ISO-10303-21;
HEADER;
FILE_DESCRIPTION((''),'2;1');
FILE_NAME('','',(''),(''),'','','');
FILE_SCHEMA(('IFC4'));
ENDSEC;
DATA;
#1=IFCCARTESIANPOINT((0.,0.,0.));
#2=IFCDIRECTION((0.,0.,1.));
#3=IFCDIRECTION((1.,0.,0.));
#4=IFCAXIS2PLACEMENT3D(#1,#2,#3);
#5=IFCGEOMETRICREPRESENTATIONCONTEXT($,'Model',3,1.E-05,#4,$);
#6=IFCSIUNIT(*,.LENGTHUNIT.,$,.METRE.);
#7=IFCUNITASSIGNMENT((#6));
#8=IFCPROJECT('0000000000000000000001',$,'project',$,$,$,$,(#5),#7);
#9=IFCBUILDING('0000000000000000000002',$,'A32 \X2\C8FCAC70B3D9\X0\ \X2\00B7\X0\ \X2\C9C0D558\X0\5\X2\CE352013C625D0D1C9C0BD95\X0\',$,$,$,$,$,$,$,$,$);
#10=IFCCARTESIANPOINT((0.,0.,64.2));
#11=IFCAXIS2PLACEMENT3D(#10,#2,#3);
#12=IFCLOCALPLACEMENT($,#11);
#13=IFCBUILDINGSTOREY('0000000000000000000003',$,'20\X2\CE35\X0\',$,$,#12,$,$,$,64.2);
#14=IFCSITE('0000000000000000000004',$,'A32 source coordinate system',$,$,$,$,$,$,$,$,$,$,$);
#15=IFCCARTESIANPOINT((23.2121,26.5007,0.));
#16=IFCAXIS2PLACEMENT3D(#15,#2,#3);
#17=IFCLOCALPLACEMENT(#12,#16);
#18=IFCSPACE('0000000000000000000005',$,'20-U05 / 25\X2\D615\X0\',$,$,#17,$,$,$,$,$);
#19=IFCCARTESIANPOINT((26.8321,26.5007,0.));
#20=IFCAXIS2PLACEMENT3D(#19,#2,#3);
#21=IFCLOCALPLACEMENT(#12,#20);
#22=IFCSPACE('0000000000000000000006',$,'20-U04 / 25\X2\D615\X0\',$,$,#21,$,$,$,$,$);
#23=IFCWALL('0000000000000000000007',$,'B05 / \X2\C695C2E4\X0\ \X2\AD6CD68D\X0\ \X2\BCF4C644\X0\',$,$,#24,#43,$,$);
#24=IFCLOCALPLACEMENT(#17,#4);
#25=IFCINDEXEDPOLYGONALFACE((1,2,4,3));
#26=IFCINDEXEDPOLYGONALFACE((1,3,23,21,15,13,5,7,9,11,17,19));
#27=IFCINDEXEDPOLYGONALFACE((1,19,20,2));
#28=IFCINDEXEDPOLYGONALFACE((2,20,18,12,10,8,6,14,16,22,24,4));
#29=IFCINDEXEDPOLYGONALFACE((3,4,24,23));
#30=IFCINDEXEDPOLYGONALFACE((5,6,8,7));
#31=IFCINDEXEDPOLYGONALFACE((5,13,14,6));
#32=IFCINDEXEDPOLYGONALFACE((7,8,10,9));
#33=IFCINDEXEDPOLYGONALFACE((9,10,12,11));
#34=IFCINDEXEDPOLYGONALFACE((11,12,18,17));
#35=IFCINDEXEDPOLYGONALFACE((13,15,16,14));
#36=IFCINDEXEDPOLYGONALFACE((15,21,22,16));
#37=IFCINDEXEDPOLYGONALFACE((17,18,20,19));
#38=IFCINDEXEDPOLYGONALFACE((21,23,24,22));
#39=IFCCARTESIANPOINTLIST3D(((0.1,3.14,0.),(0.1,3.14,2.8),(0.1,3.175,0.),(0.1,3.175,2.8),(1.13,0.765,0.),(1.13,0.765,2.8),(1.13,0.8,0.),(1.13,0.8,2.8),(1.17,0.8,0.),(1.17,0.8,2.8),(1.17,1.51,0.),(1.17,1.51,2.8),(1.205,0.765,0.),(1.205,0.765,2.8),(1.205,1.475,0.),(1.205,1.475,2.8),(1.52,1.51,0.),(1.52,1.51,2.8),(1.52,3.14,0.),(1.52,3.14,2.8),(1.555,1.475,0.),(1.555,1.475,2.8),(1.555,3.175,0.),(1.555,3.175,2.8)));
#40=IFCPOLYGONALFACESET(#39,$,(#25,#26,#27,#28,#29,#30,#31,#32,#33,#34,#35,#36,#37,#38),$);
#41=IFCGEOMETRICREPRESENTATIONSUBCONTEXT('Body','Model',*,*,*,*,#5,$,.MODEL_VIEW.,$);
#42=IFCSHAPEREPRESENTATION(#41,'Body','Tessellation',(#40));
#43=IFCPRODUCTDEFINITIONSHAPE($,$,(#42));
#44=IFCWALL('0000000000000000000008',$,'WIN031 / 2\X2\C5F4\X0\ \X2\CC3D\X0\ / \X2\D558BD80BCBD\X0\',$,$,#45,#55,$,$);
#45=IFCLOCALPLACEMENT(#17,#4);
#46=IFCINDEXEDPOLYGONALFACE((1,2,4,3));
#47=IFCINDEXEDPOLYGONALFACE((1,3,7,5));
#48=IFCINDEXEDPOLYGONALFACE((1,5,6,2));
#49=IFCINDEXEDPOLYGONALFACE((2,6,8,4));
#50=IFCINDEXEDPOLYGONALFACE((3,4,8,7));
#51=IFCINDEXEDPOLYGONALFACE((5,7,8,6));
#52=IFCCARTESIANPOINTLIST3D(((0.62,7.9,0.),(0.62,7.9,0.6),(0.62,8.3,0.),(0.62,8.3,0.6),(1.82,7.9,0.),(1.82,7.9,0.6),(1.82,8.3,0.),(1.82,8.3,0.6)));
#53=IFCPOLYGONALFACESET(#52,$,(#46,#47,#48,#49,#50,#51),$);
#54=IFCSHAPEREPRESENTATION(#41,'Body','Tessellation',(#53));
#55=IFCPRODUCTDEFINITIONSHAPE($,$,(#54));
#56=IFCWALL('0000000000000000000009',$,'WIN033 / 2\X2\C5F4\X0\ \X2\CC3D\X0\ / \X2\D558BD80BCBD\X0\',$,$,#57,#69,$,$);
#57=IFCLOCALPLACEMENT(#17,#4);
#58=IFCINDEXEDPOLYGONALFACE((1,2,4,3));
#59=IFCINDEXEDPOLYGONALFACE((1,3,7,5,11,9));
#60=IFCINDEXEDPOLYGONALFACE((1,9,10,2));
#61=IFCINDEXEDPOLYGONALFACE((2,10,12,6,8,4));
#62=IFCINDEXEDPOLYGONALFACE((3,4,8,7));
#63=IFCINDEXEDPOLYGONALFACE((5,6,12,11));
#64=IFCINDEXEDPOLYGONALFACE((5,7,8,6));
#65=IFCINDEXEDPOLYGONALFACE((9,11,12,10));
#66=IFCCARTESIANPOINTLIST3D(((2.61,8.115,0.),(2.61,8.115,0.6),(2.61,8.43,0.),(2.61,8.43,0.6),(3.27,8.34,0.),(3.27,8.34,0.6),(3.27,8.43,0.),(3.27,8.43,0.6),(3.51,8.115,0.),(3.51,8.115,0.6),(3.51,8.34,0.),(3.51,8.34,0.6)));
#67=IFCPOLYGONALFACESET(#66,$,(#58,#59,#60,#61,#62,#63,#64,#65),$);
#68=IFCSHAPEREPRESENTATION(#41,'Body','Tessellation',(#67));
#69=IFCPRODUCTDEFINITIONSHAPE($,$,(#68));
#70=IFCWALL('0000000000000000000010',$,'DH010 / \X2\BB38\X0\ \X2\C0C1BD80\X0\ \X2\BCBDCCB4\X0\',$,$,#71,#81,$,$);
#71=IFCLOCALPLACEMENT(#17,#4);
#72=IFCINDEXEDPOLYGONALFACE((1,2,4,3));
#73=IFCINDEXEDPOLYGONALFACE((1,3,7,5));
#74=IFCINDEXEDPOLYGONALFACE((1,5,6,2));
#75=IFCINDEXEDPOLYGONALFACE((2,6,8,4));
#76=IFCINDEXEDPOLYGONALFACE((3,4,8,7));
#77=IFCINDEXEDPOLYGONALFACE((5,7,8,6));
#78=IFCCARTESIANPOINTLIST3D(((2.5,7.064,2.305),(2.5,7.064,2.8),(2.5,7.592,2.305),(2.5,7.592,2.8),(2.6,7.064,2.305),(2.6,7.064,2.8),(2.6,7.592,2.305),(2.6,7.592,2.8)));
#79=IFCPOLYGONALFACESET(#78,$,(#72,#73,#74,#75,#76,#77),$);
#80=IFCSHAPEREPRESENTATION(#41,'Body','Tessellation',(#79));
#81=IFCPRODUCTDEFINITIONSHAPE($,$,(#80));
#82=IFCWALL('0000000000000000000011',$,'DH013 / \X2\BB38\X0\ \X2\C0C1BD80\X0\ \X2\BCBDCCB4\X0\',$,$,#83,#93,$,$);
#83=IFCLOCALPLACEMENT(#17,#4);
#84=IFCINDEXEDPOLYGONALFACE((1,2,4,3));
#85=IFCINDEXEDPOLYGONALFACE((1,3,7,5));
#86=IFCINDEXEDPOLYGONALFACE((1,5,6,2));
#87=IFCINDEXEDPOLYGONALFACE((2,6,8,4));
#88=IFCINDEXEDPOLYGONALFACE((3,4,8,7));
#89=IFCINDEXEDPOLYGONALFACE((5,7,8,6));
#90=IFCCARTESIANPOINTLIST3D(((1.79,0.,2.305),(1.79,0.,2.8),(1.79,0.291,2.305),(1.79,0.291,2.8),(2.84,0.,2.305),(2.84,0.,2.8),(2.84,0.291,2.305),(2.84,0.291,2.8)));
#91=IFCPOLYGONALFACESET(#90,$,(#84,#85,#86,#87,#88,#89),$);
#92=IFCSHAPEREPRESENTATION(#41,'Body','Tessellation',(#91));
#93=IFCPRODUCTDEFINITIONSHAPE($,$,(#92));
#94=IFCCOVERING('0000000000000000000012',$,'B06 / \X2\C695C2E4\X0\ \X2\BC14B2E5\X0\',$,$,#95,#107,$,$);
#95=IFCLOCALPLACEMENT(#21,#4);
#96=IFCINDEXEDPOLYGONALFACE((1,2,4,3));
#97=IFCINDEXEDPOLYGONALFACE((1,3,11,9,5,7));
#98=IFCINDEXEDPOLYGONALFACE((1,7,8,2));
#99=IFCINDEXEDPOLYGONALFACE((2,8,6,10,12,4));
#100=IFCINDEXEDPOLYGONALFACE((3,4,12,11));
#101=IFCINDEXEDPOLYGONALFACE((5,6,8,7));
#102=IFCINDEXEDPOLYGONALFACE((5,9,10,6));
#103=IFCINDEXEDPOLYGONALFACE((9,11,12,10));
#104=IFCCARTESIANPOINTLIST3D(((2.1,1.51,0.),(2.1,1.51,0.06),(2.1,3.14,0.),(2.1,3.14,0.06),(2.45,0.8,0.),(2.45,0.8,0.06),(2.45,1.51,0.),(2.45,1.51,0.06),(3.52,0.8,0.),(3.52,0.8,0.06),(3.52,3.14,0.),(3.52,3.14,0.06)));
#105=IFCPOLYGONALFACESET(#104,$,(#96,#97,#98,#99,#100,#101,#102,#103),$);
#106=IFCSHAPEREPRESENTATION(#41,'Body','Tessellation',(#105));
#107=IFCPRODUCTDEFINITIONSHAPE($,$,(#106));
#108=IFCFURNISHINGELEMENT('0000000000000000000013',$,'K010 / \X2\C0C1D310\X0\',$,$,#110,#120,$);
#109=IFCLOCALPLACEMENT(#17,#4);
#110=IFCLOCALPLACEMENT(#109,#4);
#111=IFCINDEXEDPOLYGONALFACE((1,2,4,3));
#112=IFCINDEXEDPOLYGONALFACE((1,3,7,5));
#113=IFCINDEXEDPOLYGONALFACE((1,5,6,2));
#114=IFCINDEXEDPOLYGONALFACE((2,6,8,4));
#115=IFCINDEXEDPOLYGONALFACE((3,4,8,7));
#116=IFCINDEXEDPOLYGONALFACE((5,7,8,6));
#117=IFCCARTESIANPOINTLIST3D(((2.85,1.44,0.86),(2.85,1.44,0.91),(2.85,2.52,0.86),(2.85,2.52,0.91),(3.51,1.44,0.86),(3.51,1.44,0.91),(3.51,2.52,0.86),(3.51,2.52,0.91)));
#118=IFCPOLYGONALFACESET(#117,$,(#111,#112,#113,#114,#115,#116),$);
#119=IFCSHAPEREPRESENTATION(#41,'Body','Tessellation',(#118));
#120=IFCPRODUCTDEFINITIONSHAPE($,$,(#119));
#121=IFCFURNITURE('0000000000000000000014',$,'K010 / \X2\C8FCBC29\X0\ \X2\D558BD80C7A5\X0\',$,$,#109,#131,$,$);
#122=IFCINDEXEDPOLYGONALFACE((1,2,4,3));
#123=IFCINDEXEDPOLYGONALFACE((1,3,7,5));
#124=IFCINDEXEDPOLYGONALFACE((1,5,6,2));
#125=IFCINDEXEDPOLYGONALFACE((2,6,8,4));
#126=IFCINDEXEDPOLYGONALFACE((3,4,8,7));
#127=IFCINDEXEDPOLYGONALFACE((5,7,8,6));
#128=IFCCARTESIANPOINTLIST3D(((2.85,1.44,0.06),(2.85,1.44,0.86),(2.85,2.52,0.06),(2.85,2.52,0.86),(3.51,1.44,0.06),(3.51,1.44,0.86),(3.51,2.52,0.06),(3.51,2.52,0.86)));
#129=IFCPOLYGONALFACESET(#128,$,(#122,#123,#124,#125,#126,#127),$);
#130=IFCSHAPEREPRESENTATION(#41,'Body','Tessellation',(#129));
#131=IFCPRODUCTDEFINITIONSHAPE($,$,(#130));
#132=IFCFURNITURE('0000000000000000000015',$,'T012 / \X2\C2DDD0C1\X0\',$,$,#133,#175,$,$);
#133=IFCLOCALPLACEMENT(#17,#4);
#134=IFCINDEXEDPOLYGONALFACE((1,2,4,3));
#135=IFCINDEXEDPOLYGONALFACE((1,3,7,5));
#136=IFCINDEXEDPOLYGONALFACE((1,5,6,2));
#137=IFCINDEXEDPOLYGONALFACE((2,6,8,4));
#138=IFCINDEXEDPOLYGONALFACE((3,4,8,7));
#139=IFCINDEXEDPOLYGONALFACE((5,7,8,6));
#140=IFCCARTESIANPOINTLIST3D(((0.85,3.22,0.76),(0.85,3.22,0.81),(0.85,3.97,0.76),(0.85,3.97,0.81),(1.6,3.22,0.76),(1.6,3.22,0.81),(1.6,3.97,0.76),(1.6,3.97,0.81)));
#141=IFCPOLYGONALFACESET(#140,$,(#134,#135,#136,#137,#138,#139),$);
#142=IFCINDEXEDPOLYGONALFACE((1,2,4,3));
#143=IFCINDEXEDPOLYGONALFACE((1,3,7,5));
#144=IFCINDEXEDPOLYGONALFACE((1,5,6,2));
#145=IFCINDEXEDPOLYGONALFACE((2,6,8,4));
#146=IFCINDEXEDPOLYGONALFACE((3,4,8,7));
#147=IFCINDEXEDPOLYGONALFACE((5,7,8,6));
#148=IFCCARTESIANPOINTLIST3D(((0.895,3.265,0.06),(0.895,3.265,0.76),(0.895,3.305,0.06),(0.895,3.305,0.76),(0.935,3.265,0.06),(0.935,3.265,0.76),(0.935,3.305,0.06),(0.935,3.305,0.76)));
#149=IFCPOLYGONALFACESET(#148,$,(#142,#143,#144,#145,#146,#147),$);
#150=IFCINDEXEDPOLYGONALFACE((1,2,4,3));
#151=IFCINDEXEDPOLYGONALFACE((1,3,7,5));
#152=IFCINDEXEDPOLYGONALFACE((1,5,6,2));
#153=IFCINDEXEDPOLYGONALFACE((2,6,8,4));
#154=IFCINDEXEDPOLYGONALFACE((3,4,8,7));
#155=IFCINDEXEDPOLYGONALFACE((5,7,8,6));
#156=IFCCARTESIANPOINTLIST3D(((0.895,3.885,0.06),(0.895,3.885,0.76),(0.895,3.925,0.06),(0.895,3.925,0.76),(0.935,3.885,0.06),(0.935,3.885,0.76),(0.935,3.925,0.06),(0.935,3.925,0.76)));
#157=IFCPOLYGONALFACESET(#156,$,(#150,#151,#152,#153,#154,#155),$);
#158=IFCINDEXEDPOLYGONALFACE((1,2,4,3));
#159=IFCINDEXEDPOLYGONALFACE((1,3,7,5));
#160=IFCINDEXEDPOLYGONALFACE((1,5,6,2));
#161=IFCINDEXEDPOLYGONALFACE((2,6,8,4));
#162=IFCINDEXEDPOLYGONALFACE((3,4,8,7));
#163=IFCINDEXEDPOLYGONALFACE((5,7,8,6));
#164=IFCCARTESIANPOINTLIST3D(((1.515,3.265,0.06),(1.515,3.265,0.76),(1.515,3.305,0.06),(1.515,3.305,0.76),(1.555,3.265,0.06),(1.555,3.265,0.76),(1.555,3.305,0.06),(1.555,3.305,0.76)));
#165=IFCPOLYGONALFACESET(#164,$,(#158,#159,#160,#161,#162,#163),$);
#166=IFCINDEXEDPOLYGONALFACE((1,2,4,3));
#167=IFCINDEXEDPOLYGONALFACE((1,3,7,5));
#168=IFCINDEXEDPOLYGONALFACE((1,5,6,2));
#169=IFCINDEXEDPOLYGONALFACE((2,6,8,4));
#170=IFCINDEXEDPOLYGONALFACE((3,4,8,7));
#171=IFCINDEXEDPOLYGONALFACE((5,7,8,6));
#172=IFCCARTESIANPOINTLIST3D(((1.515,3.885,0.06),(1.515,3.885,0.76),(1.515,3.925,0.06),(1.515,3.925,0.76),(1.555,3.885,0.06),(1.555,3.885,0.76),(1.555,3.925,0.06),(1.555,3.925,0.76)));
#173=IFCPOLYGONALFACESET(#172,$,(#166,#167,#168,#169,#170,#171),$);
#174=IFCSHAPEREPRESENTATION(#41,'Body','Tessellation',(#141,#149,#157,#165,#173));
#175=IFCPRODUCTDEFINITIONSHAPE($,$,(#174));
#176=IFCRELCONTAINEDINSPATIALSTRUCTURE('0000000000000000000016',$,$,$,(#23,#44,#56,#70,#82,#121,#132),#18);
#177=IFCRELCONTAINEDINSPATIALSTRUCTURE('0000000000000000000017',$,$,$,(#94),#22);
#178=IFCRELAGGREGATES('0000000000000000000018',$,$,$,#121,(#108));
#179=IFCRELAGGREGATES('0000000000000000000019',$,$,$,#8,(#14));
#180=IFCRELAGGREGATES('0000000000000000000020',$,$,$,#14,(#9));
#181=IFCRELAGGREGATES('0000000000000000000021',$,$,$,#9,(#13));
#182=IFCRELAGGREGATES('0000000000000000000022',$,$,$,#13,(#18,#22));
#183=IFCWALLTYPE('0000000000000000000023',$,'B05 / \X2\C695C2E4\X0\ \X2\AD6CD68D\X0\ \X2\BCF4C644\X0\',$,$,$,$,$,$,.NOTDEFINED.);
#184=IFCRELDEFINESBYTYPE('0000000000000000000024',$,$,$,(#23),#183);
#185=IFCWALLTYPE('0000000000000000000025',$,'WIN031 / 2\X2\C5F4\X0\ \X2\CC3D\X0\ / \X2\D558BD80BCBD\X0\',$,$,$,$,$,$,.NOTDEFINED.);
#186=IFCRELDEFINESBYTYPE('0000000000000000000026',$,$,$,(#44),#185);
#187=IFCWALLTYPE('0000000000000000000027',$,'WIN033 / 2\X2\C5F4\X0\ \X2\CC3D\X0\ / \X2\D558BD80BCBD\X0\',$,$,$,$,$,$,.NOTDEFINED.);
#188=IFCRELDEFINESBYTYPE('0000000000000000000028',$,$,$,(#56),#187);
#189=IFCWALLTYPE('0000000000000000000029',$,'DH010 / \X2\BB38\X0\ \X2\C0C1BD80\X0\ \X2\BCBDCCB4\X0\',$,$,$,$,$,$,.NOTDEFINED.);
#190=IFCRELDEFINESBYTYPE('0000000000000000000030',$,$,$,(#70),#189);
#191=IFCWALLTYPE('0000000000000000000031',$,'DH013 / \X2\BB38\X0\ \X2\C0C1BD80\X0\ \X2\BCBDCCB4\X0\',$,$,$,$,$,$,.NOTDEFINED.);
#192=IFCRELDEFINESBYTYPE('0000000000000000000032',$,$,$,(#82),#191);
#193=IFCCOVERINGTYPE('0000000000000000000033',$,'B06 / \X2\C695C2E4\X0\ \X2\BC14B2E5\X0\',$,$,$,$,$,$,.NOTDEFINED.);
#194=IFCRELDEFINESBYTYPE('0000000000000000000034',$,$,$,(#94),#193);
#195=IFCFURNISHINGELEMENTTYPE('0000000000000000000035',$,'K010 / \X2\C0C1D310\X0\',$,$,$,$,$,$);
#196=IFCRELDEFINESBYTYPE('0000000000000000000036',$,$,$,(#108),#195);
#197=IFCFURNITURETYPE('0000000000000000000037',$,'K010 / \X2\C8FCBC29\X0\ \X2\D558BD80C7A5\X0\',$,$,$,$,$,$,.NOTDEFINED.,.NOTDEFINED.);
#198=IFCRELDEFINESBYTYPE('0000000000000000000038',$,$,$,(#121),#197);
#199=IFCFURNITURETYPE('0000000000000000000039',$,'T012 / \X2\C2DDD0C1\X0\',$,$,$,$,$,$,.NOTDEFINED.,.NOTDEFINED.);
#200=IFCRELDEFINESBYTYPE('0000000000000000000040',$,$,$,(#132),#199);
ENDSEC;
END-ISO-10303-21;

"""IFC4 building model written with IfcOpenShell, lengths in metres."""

from ifc_helpers import new_model, si_unit, frame, origin, origin_with_axes, place, context, subcontext, project, spatial, polyline, outline, extrude, source, transform, mapped, type_object, type_shapes, element, aggregate, save


model = new_model("IFC4")

# Units and contexts
model_context = context("Model", 3, precision=1e-05, world=origin_with_axes())
body_context = subcontext(model_context, "Body", "Model", "MODEL_VIEW")
ifc_project = project(units=[si_unit("LENGTHUNIT", "METRE")], contexts=[model_context])

# Site, building, storey, space
site = spatial("IfcSite", under=ifc_project, Name="A32 source coordinate system")
building = spatial("IfcBuilding", under=site, Name="A32 주거동 · 지하5층–옥탑지붕")
storey_placement = place(None, frame((0.0, 0.0, 64.2), z_axis=(0.0, 0.0, 1.0), x_axis=(1.0, 0.0, 0.0)))
storey = spatial("IfcBuildingStorey", under=building, at=storey_placement, Name="20층", Elevation=64.2)
space_1_placement = place(storey_placement, frame((23.2121, 26.5007, 0.0), z_axis=(0.0, 0.0, 1.0), x_axis=(1.0, 0.0, 0.0)))
space_1 = spatial("IfcSpace", under=storey, at=space_1_placement, Name="20-U05 / 25형")

# Walls
wall_type_1 = type_object("IfcWallType", Name="B05 / 욕실 구획 보완", PredefinedType="NOTDEFINED")
shared_shape_1 = source(origin(), body_context, "Body", "SweptSolid", [
    extrude(outline(polyline([(1.17, 1.51), (1.52, 1.51), (1.52, 3.14), (0.1, 3.14), (0.1, 3.175), (1.555, 3.175), (1.555, 1.475), (1.205, 1.475), (1.205, 0.765), (1.13, 0.765), (1.13, 0.8), (1.17, 0.8), (1.17, 1.51)])), origin(), (0.0, 0.0, 1.0), 2.8),
])
type_shapes(wall_type_1, [shared_shape_1])
wall_1_placement = place(space_1_placement, origin_with_axes())
element("IfcWall", 1, at=wall_1_placement, inside=space_1, type_object=wall_type_1, Name="B05 / 욕실 구획 보완", context=body_context, shape_type="MappedRepresentation", body=[
    mapped(shared_shape_1, transform((0.0, 0.0, 0.0), scale=1.0)),
])
wall_type_2 = type_object("IfcWallType", Name="WIN031 / 2열 창 / 하부벽", PredefinedType="NOTDEFINED")
shared_shape_2 = source(origin(), body_context, "Body", "SweptSolid", [
    extrude(outline(polyline([(0.62, 8.3), (1.82, 8.3), (1.82, 7.9), (0.62, 7.9), (0.62, 8.3)])), origin(), (0.0, 0.0, 1.0), 0.6),
])
type_shapes(wall_type_2, [shared_shape_2])
wall_2_placement = place(space_1_placement, origin_with_axes())
element("IfcWall", 2, at=wall_2_placement, inside=space_1, type_object=wall_type_2, Name="WIN031 / 2열 창 / 하부벽", context=body_context, shape_type="MappedRepresentation", body=[
    mapped(shared_shape_2, transform((0.0, 0.0, 0.0), scale=1.0)),
])
wall_type_3 = type_object("IfcWallType", Name="WIN033 / 2열 창 / 하부벽", PredefinedType="NOTDEFINED")
shared_shape_3 = source(origin(), body_context, "Body", "SweptSolid", [
    extrude(outline(polyline([(2.61, 8.43), (3.27, 8.43), (3.27, 8.34), (3.51, 8.34), (3.51, 8.115), (2.61, 8.115), (2.61, 8.43)])), origin(), (0.0, 0.0, 1.0), 0.6),
])
type_shapes(wall_type_3, [shared_shape_3])
wall_3_placement = place(space_1_placement, origin_with_axes())
element("IfcWall", 3, at=wall_3_placement, inside=space_1, type_object=wall_type_3, Name="WIN033 / 2열 창 / 하부벽", context=body_context, shape_type="MappedRepresentation", body=[
    mapped(shared_shape_3, transform((0.0, 0.0, 0.0), scale=1.0)),
])
wall_type_4 = type_object("IfcWallType", Name="DH010 / 문 상부 벽체", PredefinedType="NOTDEFINED")
shared_shape_4 = source(origin(), body_context, "Body", "SweptSolid", [
    extrude(outline(polyline([(2.5, 7.592), (2.6, 7.592), (2.6, 7.064), (2.5, 7.064), (2.5, 7.592)])), frame((0.0, 0.0, 2.305)), (0.0, 0.0, 1.0), 0.495),
])
type_shapes(wall_type_4, [shared_shape_4])
wall_4_placement = place(space_1_placement, origin_with_axes())
element("IfcWall", 4, at=wall_4_placement, inside=space_1, type_object=wall_type_4, Name="DH010 / 문 상부 벽체", context=body_context, shape_type="MappedRepresentation", body=[
    mapped(shared_shape_4, transform((0.0, 0.0, 0.0), scale=1.0)),
])
wall_type_5 = type_object("IfcWallType", Name="DH013 / 문 상부 벽체", PredefinedType="NOTDEFINED")
shared_shape_5 = source(origin(), body_context, "Body", "SweptSolid", [
    extrude(outline(polyline([(2.84, 0.291), (2.84, 0.0), (1.79, 0.0), (1.79, 0.291), (2.84, 0.291)])), frame((0.0, 0.0, 2.305)), (0.0, 0.0, 1.0), 0.495),
])
type_shapes(wall_type_5, [shared_shape_5])
wall_5_placement = place(space_1_placement, origin_with_axes())
element("IfcWall", 5, at=wall_5_placement, inside=space_1, type_object=wall_type_5, Name="DH013 / 문 상부 벽체", context=body_context, shape_type="MappedRepresentation", body=[
    mapped(shared_shape_5, transform((0.0, 0.0, 0.0), scale=1.0)),
])

# Shared definitions
space_2_placement = place(storey_placement, frame((26.8321, 26.5007, 0.0), z_axis=(0.0, 0.0, 1.0), x_axis=(1.0, 0.0, 0.0)))
space_2 = spatial("IfcSpace", under=storey, at=space_2_placement, Name="20-U04 / 25형")

# Covering
covering_type = type_object("IfcCoveringType", Name="B06 / 욕실 바닥", PredefinedType="NOTDEFINED")
shared_shape_6 = source(origin(), body_context, "Body", "SweptSolid", [
    extrude(outline(polyline([(2.1, 3.14), (3.52, 3.14), (3.52, 0.8), (2.45, 0.8), (2.45, 1.51), (2.1, 1.51), (2.1, 3.14)])), origin(), (0.0, 0.0, 1.0), 0.06),
])
type_shapes(covering_type, [shared_shape_6])
covering_placement = place(space_2_placement, origin_with_axes())
element("IfcCovering", 6, at=covering_placement, inside=space_2, type_object=covering_type, Name="B06 / 욕실 바닥", context=body_context, shape_type="MappedRepresentation", body=[
    mapped(shared_shape_6, transform((0.0, 0.0, 0.0), scale=1.0)),
])

# Furnishing element
furnishing_element_type_1 = type_object("IfcFurnishingElementType", Name="K010 / 상판")
shared_shape_7 = source(origin(), body_context, "Body", "SweptSolid", [
    extrude(outline(polyline([(2.85, 2.52), (3.51, 2.52), (3.51, 1.44), (2.85, 1.44), (2.85, 2.52)])), frame((0.0, 0.0, 0.86)), (0.0, 0.0, 1.0), 0.05),
])
type_shapes(furnishing_element_type_1, [shared_shape_7])
furniture_1_placement = place(space_1_placement, origin_with_axes())
furnishing_1_placement = place(furniture_1_placement, origin_with_axes())
furnishing_1 = element("IfcFurnishingElement", 7, at=furnishing_1_placement, type_object=furnishing_element_type_1, Name="K010 / 상판", context=body_context, shape_type="MappedRepresentation", body=[
    mapped(shared_shape_7, transform((0.0, 0.0, 0.0), scale=1.0)),
])

# Furniture
furniture_type_1 = type_object("IfcFurnitureType", Name="K010 / 주방 하부장", AssemblyPlace="NOTDEFINED", PredefinedType="NOTDEFINED")
shared_shape_8 = source(origin(), body_context, "Body", "SweptSolid", [
    extrude(outline(polyline([(2.85, 1.44), (2.85, 2.52), (3.51, 2.52), (3.51, 1.44), (2.85, 1.44)])), frame((0.0, 0.0, 0.06)), (0.0, 0.0, 1.0), 0.8),
])
type_shapes(furniture_type_1, [shared_shape_8])
furniture_1 = element("IfcFurniture", 8, at=furniture_1_placement, inside=space_1, type_object=furniture_type_1, Name="K010 / 주방 하부장", context=body_context, shape_type="MappedRepresentation", body=[
    mapped(shared_shape_8, transform((0.0, 0.0, 0.0), scale=1.0)),
])
aggregate(furniture_1, [furnishing_1])
furniture_type_2 = type_object("IfcFurnitureType", Name="T012 / 식탁", AssemblyPlace="NOTDEFINED", PredefinedType="NOTDEFINED")
shared_shape_9 = source(origin(), body_context, "Body", "SweptSolid", [
    extrude(outline(polyline([(1.6, 3.97), (1.6, 3.22), (0.85, 3.22), (0.85, 3.97), (1.6, 3.97)])), frame((0.0, 0.0, 0.76)), (0.0, 0.0, 1.0), 0.05),
    extrude(outline(polyline([(0.895, 3.265), (0.895, 3.305), (0.935, 3.305), (0.935, 3.265), (0.895, 3.265)])), frame((0.0, 0.0, 0.06)), (0.0, 0.0, 1.0), 0.7),
    extrude(outline(polyline([(0.895, 3.885), (0.895, 3.925), (0.935, 3.925), (0.935, 3.885), (0.895, 3.885)])), frame((0.0, 0.0, 0.06)), (0.0, 0.0, 1.0), 0.7),
    extrude(outline(polyline([(1.515, 3.265), (1.515, 3.305), (1.555, 3.305), (1.555, 3.265), (1.515, 3.265)])), frame((0.0, 0.0, 0.06)), (0.0, 0.0, 1.0), 0.7),
    extrude(outline(polyline([(1.515, 3.885), (1.515, 3.925), (1.555, 3.925), (1.555, 3.885), (1.515, 3.885)])), frame((0.0, 0.0, 0.06)), (0.0, 0.0, 1.0), 0.7),
])
type_shapes(furniture_type_2, [shared_shape_9])
furniture_2_placement = place(space_1_placement, origin_with_axes())
element("IfcFurniture", 9, at=furniture_2_placement, inside=space_1, type_object=furniture_type_2, Name="T012 / 식탁", context=body_context, shape_type="MappedRepresentation", body=[
    mapped(shared_shape_9, transform((0.0, 0.0, 0.0), scale=1.0)),
])

save(model, "model.ifc")
